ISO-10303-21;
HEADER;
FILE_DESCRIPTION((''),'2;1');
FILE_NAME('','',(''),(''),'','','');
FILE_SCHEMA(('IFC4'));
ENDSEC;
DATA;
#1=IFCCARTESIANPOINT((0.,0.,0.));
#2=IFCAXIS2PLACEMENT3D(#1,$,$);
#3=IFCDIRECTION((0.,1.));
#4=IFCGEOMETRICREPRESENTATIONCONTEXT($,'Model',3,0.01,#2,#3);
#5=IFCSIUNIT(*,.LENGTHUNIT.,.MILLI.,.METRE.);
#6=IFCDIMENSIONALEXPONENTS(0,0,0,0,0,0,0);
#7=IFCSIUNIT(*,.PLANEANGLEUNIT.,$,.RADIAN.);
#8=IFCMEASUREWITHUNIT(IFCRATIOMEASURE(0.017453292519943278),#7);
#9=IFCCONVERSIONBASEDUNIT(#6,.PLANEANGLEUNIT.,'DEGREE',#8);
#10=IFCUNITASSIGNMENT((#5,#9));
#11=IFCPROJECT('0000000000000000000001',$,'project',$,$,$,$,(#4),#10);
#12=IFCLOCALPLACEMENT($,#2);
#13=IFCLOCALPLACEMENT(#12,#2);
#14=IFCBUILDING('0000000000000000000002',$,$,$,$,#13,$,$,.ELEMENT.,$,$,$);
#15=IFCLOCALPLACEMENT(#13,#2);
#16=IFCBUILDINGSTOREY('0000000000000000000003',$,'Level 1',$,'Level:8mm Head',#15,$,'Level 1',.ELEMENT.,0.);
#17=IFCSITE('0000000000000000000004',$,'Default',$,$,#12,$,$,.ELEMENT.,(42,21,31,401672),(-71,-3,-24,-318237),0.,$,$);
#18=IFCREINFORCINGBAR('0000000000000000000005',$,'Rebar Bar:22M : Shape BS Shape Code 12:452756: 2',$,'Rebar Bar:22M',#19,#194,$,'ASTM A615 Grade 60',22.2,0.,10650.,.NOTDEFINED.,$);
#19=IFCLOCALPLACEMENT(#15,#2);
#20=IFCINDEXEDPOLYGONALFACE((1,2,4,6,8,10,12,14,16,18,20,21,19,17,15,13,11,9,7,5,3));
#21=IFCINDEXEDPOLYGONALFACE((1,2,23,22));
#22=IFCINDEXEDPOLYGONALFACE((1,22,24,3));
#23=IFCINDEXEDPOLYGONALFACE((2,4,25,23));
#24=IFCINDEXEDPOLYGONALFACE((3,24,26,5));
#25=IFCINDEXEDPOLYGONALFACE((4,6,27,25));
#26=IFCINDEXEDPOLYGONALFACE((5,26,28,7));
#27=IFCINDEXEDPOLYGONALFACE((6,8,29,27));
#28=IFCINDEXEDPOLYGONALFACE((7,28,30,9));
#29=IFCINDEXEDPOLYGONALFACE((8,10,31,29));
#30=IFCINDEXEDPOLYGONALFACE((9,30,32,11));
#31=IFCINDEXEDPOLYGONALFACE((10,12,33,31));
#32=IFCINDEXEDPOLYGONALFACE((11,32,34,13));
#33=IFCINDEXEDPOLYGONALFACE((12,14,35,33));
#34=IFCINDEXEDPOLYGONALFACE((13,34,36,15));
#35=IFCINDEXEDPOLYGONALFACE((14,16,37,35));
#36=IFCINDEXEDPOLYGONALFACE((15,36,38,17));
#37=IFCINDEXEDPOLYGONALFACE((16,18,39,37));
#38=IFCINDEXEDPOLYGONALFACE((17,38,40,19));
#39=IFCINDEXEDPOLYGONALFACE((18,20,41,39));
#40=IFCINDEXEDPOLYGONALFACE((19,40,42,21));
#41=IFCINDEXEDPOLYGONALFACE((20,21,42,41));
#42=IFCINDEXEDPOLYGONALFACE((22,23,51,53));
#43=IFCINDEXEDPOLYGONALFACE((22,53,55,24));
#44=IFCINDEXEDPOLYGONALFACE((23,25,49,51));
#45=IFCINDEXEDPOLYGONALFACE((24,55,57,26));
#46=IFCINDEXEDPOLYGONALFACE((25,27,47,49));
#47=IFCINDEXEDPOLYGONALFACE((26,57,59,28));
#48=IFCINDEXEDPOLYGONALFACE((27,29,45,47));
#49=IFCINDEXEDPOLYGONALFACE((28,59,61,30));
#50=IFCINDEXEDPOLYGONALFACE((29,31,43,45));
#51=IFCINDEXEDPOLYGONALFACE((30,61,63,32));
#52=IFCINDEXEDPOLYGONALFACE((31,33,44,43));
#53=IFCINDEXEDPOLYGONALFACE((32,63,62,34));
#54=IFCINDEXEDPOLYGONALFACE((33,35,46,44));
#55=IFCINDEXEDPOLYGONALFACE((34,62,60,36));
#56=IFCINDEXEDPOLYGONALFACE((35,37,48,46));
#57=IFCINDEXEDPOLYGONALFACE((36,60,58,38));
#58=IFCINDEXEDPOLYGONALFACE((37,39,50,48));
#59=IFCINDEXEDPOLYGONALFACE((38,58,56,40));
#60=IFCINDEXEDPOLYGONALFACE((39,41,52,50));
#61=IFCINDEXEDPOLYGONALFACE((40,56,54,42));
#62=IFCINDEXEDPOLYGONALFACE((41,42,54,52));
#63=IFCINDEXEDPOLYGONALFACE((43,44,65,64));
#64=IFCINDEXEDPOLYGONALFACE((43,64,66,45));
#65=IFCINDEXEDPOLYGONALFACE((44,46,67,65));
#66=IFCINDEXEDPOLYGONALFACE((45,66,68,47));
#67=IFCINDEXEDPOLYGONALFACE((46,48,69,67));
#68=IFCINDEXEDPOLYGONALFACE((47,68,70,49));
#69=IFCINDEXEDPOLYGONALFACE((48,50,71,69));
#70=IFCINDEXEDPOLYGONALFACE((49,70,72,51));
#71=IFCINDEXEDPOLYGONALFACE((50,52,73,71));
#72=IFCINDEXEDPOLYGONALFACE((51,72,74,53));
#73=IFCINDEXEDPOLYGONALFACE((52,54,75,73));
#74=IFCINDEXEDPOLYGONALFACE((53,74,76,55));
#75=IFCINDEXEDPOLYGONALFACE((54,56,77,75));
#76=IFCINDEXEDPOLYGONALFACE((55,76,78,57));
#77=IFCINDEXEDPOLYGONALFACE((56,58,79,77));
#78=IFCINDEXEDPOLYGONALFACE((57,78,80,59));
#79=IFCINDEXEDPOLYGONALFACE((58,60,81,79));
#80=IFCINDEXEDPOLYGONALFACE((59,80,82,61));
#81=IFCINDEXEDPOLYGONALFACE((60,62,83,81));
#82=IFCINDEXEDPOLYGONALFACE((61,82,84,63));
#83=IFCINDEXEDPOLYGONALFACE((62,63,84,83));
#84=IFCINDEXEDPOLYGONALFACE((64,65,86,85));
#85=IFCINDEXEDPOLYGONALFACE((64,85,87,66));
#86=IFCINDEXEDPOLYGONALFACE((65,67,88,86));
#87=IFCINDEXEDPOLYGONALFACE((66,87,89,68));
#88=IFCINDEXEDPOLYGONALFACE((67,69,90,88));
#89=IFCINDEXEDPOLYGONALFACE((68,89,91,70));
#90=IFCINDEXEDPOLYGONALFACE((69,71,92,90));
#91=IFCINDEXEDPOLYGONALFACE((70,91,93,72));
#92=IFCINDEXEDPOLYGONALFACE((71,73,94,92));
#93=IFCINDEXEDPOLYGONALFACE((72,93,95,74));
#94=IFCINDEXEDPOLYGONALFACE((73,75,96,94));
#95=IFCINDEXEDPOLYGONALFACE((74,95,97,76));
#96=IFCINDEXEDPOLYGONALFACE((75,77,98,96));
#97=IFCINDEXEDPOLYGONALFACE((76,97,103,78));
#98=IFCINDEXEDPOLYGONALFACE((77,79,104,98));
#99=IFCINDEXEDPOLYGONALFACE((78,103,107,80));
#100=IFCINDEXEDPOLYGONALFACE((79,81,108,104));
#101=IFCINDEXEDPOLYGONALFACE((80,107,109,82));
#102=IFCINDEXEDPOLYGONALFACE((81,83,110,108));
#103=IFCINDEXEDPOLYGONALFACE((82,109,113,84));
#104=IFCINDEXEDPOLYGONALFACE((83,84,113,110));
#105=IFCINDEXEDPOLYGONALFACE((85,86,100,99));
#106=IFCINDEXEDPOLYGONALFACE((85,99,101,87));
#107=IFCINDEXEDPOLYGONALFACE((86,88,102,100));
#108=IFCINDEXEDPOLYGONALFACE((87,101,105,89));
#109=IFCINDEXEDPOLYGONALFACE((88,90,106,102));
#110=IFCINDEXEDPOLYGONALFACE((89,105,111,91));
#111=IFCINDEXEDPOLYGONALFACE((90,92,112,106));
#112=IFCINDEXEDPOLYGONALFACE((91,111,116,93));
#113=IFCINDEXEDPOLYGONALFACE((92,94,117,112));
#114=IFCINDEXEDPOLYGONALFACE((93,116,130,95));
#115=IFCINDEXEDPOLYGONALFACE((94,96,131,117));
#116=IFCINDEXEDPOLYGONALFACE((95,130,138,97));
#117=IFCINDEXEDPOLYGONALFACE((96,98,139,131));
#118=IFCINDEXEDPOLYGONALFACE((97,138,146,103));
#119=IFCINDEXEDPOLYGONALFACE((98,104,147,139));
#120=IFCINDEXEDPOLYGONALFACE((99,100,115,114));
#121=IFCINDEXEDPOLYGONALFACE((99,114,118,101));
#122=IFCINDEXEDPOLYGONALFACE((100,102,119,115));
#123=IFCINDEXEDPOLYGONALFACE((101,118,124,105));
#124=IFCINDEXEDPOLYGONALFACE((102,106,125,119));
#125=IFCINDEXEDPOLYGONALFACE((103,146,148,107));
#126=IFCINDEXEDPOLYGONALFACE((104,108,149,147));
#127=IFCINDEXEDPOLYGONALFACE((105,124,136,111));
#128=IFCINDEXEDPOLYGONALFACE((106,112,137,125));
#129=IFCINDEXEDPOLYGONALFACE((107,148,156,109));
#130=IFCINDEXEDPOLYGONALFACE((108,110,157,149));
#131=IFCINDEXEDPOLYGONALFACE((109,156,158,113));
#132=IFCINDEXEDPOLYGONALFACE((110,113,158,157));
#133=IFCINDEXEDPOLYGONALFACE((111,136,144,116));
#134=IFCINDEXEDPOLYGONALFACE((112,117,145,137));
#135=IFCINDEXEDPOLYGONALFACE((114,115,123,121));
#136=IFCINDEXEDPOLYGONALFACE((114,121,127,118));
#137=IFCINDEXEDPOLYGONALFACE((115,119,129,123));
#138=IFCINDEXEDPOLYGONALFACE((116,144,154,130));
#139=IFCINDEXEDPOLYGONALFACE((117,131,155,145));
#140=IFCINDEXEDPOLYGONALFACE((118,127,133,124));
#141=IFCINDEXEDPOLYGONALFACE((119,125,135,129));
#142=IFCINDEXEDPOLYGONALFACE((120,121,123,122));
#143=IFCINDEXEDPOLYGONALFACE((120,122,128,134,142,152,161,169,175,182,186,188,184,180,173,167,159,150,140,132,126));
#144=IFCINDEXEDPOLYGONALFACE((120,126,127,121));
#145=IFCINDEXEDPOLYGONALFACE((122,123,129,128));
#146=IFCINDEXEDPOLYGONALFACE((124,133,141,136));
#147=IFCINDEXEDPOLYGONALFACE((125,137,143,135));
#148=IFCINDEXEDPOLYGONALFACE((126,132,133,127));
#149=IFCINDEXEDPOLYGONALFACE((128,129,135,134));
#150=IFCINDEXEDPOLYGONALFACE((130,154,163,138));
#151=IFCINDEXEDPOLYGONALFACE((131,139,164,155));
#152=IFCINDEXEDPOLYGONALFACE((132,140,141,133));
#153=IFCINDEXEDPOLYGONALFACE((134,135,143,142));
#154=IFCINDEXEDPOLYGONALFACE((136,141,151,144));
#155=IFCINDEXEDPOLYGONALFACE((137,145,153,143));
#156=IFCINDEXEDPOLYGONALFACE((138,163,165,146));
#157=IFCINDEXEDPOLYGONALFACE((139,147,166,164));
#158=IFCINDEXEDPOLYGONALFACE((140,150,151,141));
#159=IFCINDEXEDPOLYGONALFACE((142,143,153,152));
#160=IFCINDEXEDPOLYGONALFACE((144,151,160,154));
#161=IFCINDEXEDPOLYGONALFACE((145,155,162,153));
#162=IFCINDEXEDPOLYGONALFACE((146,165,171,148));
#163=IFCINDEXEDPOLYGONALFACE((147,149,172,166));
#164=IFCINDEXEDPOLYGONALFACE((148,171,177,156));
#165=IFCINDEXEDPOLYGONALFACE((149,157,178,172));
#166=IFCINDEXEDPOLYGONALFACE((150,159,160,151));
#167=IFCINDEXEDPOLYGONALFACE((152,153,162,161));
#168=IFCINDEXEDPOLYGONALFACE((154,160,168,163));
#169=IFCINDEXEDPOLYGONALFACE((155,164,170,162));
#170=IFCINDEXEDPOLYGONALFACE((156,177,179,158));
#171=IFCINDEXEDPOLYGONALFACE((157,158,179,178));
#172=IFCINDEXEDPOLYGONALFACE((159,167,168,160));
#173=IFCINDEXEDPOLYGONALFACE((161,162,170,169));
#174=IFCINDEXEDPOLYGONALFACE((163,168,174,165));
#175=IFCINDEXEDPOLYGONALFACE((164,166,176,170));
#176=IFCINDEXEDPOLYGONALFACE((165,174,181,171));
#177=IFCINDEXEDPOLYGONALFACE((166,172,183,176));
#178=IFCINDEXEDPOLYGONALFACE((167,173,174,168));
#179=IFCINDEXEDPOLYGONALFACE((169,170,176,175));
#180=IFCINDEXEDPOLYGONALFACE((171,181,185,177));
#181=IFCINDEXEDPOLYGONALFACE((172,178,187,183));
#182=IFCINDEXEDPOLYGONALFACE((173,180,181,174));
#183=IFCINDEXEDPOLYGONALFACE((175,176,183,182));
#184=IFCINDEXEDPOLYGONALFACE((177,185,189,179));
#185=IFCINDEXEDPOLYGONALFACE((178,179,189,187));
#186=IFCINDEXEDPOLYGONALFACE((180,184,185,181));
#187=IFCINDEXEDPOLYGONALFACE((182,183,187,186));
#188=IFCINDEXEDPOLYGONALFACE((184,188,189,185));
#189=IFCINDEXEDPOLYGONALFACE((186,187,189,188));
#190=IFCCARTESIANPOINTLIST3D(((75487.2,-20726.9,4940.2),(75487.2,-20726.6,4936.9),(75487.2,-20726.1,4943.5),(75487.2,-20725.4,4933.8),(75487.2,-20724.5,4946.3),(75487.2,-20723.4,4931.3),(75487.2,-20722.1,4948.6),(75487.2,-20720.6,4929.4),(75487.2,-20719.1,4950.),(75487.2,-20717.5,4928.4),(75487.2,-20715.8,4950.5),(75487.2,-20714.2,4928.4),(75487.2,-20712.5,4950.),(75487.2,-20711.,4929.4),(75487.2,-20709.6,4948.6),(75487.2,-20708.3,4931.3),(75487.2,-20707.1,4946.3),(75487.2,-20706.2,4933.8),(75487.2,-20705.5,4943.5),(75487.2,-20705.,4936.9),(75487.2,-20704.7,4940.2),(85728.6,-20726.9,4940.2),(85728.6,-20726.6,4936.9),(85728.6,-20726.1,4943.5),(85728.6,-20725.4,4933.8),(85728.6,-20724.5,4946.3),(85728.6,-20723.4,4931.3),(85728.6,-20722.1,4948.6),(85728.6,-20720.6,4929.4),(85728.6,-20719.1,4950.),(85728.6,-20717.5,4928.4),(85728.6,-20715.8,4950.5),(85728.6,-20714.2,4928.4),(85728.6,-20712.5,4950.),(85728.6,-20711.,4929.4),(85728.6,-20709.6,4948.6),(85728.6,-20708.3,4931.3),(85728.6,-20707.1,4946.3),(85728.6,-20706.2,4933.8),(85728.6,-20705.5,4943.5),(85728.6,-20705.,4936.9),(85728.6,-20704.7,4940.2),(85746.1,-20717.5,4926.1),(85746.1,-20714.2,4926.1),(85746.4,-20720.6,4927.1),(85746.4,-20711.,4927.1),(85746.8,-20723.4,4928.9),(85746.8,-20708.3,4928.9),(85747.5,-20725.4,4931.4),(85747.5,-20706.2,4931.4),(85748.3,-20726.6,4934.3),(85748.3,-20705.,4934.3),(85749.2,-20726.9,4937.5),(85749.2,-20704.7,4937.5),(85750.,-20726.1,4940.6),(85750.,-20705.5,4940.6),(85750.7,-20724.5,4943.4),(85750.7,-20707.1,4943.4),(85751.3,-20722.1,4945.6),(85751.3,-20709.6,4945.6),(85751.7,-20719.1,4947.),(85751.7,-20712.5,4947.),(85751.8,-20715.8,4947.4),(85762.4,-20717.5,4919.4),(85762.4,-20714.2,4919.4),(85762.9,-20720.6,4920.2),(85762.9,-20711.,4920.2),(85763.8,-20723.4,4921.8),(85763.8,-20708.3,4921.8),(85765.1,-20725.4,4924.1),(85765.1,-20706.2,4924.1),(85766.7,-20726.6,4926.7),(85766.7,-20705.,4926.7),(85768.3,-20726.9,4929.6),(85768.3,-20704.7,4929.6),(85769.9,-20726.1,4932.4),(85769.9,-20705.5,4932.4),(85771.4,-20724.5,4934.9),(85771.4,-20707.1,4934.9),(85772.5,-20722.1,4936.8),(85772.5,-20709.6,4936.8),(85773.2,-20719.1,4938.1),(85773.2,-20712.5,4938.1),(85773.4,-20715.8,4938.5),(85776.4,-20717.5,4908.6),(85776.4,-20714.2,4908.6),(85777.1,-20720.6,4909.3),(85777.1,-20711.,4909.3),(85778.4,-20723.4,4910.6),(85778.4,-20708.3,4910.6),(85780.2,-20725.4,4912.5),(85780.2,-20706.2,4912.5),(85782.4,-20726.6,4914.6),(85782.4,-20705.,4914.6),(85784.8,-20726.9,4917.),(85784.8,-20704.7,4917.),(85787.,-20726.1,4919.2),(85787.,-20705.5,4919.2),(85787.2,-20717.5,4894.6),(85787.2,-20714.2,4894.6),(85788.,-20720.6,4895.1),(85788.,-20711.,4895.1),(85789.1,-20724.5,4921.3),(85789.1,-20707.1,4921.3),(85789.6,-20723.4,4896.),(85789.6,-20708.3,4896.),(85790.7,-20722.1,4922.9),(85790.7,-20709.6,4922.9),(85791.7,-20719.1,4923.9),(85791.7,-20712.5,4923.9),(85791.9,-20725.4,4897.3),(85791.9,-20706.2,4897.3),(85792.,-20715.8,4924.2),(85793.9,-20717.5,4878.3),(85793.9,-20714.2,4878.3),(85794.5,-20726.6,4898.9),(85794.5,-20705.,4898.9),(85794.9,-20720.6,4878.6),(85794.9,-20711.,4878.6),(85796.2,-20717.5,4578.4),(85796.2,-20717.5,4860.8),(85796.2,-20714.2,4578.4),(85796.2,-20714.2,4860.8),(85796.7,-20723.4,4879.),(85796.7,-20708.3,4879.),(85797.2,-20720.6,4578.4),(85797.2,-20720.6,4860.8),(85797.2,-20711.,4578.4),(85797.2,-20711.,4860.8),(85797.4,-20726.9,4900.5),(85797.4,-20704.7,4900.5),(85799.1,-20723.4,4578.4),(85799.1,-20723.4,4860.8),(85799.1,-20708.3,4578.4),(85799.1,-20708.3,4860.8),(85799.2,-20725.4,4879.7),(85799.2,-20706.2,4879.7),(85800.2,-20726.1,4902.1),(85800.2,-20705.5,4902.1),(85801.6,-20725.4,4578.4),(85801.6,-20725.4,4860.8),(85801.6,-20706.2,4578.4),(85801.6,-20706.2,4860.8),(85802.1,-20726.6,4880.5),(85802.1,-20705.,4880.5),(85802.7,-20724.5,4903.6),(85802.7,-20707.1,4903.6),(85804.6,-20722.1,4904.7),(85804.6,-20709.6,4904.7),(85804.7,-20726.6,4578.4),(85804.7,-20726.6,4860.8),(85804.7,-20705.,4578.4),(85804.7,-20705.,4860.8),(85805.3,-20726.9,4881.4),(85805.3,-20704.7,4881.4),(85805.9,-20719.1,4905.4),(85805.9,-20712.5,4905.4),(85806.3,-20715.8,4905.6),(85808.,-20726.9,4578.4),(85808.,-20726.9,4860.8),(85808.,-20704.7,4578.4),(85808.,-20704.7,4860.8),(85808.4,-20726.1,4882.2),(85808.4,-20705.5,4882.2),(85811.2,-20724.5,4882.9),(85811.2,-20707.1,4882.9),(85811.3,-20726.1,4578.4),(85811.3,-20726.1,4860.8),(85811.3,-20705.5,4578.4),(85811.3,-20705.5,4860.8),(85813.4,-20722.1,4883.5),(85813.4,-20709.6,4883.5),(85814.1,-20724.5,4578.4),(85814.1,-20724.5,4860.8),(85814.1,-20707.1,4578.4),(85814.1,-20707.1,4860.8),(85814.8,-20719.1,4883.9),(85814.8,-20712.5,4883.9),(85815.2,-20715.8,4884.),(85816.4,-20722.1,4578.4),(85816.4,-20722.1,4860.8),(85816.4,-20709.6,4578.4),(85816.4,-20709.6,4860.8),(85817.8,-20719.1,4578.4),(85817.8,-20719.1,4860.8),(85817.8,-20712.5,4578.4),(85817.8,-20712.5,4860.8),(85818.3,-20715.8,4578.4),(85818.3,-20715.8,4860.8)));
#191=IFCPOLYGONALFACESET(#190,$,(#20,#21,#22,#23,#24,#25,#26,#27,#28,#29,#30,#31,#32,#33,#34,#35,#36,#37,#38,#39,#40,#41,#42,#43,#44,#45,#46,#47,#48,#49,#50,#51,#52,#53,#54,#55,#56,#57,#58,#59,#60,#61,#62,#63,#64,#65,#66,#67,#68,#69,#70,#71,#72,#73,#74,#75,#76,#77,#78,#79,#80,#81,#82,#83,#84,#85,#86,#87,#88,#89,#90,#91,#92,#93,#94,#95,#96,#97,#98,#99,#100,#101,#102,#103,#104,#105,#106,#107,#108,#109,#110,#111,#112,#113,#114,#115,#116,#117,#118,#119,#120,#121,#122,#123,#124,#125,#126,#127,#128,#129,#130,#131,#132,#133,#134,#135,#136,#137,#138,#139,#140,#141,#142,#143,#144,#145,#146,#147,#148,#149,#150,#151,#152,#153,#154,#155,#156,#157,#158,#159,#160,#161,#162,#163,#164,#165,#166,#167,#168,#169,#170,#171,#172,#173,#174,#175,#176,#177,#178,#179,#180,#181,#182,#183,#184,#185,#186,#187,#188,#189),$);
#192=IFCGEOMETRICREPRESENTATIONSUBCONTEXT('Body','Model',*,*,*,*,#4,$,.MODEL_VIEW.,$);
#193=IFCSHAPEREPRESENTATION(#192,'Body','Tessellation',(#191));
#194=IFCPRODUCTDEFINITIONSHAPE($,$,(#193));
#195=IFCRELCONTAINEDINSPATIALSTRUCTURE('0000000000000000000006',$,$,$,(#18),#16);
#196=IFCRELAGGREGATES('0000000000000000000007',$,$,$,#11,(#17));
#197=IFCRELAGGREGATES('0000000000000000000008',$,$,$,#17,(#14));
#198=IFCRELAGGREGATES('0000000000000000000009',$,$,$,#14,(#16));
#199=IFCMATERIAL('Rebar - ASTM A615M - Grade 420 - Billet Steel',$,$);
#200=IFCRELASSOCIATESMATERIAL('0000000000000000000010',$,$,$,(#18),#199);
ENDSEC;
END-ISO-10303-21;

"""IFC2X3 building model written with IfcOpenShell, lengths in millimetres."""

from ifc_helpers import new_model, entity, si_unit, converted_unit, direction, origin, place, context, subcontext, project, spatial, material, element, save


model = new_model("IFC2X3")

# Units and contexts
model_context = context("Model", 3, precision=0.01, world=origin(), true_north=direction((0.0, 1.0)))
body_context = subcontext(model_context, "Body", "Model", "MODEL_VIEW")
ifc_project = project(units=[si_unit("LENGTHUNIT", "METRE", prefix="MILLI"), converted_unit("PLANEANGLEUNIT", "DEGREE", entity("IfcRatioMeasure", 0.017453292519943278), si_unit("PLANEANGLEUNIT", "RADIAN"), dimensions=[0, 0, 0, 0, 0, 0, 0])], contexts=[model_context])

# Site, building, storey
site_placement = place(None, origin())
site = spatial("IfcSite", under=ifc_project, at=site_placement, Name="Default", CompositionType="ELEMENT", RefLatitude=(42, 21, 31, 401672), RefLongitude=(-71, -3, -24, -318237), RefElevation=0.0)
building_placement = place(site_placement, origin())
building = spatial("IfcBuilding", under=site, at=building_placement, CompositionType="ELEMENT")
storey_placement = place(building_placement, origin())
storey = spatial("IfcBuildingStorey", under=building, at=storey_placement, Name="Level 1", ObjectType="Level:8mm Head", LongName="Level 1", CompositionType="ELEMENT", Elevation=0.0)

# Reinforcing bar
ifc_material = material(Name="Rebar - ASTM A615M - Grade 420 - Billet Steel")
reinforcing_bar_1_placement = place(storey_placement, origin())
element("IfcReinforcingBar", 1, at=reinforcing_bar_1_placement, inside=storey, material=ifc_material, Name="Rebar Bar:22M : Shape BS Shape Code 12:452756: 2", SteelGrade="ASTM A615 Grade 60", ObjectType="Rebar Bar:22M", BarLength=10650.0, BarRole="NOTDEFINED", CrossSectionArea=0.0, NominalDiameter=22.2, context=body_context, shape_type="AdvancedSweptSolid", body=[
    entity("IfcSweptDiskSolid", entity("IfcCompositeCurve", [entity("IfcCompositeCurveSegment", "CONTINUOUS", True, entity("IfcPolyline", [entity("IfcCartesianPoint", [75487.2, -20715.8, 4939.4]), entity("IfcCartesianPoint", [85728.6, -20715.8, 4939.4])])), entity("IfcCompositeCurveSegment", "CONTINUOUS", True, entity("IfcTrimmedCurve", entity("IfcCircle", entity("IfcAxis2Placement3D", entity("IfcCartesianPoint", [85728.6, -20715.8, 4860.8]), entity("IfcDirection", [0.0, 1.0, 0.0]), entity("IfcDirection", [1.0, 0.0, 0.0])), 78.6), [entity("IfcParameterValue", 270.0)], [entity("IfcParameterValue", 360.0)], True, "PARAMETER")), entity("IfcCompositeCurveSegment", "CONTINUOUS", True, entity("IfcPolyline", [entity("IfcCartesianPoint", [85807.2, -20715.8, 4860.8]), entity("IfcCartesianPoint", [85807.2, -20715.8, 4578.4])]))], False), 11.1, None, 0.0, 92.0),
])

save(model, "model.ifc")
